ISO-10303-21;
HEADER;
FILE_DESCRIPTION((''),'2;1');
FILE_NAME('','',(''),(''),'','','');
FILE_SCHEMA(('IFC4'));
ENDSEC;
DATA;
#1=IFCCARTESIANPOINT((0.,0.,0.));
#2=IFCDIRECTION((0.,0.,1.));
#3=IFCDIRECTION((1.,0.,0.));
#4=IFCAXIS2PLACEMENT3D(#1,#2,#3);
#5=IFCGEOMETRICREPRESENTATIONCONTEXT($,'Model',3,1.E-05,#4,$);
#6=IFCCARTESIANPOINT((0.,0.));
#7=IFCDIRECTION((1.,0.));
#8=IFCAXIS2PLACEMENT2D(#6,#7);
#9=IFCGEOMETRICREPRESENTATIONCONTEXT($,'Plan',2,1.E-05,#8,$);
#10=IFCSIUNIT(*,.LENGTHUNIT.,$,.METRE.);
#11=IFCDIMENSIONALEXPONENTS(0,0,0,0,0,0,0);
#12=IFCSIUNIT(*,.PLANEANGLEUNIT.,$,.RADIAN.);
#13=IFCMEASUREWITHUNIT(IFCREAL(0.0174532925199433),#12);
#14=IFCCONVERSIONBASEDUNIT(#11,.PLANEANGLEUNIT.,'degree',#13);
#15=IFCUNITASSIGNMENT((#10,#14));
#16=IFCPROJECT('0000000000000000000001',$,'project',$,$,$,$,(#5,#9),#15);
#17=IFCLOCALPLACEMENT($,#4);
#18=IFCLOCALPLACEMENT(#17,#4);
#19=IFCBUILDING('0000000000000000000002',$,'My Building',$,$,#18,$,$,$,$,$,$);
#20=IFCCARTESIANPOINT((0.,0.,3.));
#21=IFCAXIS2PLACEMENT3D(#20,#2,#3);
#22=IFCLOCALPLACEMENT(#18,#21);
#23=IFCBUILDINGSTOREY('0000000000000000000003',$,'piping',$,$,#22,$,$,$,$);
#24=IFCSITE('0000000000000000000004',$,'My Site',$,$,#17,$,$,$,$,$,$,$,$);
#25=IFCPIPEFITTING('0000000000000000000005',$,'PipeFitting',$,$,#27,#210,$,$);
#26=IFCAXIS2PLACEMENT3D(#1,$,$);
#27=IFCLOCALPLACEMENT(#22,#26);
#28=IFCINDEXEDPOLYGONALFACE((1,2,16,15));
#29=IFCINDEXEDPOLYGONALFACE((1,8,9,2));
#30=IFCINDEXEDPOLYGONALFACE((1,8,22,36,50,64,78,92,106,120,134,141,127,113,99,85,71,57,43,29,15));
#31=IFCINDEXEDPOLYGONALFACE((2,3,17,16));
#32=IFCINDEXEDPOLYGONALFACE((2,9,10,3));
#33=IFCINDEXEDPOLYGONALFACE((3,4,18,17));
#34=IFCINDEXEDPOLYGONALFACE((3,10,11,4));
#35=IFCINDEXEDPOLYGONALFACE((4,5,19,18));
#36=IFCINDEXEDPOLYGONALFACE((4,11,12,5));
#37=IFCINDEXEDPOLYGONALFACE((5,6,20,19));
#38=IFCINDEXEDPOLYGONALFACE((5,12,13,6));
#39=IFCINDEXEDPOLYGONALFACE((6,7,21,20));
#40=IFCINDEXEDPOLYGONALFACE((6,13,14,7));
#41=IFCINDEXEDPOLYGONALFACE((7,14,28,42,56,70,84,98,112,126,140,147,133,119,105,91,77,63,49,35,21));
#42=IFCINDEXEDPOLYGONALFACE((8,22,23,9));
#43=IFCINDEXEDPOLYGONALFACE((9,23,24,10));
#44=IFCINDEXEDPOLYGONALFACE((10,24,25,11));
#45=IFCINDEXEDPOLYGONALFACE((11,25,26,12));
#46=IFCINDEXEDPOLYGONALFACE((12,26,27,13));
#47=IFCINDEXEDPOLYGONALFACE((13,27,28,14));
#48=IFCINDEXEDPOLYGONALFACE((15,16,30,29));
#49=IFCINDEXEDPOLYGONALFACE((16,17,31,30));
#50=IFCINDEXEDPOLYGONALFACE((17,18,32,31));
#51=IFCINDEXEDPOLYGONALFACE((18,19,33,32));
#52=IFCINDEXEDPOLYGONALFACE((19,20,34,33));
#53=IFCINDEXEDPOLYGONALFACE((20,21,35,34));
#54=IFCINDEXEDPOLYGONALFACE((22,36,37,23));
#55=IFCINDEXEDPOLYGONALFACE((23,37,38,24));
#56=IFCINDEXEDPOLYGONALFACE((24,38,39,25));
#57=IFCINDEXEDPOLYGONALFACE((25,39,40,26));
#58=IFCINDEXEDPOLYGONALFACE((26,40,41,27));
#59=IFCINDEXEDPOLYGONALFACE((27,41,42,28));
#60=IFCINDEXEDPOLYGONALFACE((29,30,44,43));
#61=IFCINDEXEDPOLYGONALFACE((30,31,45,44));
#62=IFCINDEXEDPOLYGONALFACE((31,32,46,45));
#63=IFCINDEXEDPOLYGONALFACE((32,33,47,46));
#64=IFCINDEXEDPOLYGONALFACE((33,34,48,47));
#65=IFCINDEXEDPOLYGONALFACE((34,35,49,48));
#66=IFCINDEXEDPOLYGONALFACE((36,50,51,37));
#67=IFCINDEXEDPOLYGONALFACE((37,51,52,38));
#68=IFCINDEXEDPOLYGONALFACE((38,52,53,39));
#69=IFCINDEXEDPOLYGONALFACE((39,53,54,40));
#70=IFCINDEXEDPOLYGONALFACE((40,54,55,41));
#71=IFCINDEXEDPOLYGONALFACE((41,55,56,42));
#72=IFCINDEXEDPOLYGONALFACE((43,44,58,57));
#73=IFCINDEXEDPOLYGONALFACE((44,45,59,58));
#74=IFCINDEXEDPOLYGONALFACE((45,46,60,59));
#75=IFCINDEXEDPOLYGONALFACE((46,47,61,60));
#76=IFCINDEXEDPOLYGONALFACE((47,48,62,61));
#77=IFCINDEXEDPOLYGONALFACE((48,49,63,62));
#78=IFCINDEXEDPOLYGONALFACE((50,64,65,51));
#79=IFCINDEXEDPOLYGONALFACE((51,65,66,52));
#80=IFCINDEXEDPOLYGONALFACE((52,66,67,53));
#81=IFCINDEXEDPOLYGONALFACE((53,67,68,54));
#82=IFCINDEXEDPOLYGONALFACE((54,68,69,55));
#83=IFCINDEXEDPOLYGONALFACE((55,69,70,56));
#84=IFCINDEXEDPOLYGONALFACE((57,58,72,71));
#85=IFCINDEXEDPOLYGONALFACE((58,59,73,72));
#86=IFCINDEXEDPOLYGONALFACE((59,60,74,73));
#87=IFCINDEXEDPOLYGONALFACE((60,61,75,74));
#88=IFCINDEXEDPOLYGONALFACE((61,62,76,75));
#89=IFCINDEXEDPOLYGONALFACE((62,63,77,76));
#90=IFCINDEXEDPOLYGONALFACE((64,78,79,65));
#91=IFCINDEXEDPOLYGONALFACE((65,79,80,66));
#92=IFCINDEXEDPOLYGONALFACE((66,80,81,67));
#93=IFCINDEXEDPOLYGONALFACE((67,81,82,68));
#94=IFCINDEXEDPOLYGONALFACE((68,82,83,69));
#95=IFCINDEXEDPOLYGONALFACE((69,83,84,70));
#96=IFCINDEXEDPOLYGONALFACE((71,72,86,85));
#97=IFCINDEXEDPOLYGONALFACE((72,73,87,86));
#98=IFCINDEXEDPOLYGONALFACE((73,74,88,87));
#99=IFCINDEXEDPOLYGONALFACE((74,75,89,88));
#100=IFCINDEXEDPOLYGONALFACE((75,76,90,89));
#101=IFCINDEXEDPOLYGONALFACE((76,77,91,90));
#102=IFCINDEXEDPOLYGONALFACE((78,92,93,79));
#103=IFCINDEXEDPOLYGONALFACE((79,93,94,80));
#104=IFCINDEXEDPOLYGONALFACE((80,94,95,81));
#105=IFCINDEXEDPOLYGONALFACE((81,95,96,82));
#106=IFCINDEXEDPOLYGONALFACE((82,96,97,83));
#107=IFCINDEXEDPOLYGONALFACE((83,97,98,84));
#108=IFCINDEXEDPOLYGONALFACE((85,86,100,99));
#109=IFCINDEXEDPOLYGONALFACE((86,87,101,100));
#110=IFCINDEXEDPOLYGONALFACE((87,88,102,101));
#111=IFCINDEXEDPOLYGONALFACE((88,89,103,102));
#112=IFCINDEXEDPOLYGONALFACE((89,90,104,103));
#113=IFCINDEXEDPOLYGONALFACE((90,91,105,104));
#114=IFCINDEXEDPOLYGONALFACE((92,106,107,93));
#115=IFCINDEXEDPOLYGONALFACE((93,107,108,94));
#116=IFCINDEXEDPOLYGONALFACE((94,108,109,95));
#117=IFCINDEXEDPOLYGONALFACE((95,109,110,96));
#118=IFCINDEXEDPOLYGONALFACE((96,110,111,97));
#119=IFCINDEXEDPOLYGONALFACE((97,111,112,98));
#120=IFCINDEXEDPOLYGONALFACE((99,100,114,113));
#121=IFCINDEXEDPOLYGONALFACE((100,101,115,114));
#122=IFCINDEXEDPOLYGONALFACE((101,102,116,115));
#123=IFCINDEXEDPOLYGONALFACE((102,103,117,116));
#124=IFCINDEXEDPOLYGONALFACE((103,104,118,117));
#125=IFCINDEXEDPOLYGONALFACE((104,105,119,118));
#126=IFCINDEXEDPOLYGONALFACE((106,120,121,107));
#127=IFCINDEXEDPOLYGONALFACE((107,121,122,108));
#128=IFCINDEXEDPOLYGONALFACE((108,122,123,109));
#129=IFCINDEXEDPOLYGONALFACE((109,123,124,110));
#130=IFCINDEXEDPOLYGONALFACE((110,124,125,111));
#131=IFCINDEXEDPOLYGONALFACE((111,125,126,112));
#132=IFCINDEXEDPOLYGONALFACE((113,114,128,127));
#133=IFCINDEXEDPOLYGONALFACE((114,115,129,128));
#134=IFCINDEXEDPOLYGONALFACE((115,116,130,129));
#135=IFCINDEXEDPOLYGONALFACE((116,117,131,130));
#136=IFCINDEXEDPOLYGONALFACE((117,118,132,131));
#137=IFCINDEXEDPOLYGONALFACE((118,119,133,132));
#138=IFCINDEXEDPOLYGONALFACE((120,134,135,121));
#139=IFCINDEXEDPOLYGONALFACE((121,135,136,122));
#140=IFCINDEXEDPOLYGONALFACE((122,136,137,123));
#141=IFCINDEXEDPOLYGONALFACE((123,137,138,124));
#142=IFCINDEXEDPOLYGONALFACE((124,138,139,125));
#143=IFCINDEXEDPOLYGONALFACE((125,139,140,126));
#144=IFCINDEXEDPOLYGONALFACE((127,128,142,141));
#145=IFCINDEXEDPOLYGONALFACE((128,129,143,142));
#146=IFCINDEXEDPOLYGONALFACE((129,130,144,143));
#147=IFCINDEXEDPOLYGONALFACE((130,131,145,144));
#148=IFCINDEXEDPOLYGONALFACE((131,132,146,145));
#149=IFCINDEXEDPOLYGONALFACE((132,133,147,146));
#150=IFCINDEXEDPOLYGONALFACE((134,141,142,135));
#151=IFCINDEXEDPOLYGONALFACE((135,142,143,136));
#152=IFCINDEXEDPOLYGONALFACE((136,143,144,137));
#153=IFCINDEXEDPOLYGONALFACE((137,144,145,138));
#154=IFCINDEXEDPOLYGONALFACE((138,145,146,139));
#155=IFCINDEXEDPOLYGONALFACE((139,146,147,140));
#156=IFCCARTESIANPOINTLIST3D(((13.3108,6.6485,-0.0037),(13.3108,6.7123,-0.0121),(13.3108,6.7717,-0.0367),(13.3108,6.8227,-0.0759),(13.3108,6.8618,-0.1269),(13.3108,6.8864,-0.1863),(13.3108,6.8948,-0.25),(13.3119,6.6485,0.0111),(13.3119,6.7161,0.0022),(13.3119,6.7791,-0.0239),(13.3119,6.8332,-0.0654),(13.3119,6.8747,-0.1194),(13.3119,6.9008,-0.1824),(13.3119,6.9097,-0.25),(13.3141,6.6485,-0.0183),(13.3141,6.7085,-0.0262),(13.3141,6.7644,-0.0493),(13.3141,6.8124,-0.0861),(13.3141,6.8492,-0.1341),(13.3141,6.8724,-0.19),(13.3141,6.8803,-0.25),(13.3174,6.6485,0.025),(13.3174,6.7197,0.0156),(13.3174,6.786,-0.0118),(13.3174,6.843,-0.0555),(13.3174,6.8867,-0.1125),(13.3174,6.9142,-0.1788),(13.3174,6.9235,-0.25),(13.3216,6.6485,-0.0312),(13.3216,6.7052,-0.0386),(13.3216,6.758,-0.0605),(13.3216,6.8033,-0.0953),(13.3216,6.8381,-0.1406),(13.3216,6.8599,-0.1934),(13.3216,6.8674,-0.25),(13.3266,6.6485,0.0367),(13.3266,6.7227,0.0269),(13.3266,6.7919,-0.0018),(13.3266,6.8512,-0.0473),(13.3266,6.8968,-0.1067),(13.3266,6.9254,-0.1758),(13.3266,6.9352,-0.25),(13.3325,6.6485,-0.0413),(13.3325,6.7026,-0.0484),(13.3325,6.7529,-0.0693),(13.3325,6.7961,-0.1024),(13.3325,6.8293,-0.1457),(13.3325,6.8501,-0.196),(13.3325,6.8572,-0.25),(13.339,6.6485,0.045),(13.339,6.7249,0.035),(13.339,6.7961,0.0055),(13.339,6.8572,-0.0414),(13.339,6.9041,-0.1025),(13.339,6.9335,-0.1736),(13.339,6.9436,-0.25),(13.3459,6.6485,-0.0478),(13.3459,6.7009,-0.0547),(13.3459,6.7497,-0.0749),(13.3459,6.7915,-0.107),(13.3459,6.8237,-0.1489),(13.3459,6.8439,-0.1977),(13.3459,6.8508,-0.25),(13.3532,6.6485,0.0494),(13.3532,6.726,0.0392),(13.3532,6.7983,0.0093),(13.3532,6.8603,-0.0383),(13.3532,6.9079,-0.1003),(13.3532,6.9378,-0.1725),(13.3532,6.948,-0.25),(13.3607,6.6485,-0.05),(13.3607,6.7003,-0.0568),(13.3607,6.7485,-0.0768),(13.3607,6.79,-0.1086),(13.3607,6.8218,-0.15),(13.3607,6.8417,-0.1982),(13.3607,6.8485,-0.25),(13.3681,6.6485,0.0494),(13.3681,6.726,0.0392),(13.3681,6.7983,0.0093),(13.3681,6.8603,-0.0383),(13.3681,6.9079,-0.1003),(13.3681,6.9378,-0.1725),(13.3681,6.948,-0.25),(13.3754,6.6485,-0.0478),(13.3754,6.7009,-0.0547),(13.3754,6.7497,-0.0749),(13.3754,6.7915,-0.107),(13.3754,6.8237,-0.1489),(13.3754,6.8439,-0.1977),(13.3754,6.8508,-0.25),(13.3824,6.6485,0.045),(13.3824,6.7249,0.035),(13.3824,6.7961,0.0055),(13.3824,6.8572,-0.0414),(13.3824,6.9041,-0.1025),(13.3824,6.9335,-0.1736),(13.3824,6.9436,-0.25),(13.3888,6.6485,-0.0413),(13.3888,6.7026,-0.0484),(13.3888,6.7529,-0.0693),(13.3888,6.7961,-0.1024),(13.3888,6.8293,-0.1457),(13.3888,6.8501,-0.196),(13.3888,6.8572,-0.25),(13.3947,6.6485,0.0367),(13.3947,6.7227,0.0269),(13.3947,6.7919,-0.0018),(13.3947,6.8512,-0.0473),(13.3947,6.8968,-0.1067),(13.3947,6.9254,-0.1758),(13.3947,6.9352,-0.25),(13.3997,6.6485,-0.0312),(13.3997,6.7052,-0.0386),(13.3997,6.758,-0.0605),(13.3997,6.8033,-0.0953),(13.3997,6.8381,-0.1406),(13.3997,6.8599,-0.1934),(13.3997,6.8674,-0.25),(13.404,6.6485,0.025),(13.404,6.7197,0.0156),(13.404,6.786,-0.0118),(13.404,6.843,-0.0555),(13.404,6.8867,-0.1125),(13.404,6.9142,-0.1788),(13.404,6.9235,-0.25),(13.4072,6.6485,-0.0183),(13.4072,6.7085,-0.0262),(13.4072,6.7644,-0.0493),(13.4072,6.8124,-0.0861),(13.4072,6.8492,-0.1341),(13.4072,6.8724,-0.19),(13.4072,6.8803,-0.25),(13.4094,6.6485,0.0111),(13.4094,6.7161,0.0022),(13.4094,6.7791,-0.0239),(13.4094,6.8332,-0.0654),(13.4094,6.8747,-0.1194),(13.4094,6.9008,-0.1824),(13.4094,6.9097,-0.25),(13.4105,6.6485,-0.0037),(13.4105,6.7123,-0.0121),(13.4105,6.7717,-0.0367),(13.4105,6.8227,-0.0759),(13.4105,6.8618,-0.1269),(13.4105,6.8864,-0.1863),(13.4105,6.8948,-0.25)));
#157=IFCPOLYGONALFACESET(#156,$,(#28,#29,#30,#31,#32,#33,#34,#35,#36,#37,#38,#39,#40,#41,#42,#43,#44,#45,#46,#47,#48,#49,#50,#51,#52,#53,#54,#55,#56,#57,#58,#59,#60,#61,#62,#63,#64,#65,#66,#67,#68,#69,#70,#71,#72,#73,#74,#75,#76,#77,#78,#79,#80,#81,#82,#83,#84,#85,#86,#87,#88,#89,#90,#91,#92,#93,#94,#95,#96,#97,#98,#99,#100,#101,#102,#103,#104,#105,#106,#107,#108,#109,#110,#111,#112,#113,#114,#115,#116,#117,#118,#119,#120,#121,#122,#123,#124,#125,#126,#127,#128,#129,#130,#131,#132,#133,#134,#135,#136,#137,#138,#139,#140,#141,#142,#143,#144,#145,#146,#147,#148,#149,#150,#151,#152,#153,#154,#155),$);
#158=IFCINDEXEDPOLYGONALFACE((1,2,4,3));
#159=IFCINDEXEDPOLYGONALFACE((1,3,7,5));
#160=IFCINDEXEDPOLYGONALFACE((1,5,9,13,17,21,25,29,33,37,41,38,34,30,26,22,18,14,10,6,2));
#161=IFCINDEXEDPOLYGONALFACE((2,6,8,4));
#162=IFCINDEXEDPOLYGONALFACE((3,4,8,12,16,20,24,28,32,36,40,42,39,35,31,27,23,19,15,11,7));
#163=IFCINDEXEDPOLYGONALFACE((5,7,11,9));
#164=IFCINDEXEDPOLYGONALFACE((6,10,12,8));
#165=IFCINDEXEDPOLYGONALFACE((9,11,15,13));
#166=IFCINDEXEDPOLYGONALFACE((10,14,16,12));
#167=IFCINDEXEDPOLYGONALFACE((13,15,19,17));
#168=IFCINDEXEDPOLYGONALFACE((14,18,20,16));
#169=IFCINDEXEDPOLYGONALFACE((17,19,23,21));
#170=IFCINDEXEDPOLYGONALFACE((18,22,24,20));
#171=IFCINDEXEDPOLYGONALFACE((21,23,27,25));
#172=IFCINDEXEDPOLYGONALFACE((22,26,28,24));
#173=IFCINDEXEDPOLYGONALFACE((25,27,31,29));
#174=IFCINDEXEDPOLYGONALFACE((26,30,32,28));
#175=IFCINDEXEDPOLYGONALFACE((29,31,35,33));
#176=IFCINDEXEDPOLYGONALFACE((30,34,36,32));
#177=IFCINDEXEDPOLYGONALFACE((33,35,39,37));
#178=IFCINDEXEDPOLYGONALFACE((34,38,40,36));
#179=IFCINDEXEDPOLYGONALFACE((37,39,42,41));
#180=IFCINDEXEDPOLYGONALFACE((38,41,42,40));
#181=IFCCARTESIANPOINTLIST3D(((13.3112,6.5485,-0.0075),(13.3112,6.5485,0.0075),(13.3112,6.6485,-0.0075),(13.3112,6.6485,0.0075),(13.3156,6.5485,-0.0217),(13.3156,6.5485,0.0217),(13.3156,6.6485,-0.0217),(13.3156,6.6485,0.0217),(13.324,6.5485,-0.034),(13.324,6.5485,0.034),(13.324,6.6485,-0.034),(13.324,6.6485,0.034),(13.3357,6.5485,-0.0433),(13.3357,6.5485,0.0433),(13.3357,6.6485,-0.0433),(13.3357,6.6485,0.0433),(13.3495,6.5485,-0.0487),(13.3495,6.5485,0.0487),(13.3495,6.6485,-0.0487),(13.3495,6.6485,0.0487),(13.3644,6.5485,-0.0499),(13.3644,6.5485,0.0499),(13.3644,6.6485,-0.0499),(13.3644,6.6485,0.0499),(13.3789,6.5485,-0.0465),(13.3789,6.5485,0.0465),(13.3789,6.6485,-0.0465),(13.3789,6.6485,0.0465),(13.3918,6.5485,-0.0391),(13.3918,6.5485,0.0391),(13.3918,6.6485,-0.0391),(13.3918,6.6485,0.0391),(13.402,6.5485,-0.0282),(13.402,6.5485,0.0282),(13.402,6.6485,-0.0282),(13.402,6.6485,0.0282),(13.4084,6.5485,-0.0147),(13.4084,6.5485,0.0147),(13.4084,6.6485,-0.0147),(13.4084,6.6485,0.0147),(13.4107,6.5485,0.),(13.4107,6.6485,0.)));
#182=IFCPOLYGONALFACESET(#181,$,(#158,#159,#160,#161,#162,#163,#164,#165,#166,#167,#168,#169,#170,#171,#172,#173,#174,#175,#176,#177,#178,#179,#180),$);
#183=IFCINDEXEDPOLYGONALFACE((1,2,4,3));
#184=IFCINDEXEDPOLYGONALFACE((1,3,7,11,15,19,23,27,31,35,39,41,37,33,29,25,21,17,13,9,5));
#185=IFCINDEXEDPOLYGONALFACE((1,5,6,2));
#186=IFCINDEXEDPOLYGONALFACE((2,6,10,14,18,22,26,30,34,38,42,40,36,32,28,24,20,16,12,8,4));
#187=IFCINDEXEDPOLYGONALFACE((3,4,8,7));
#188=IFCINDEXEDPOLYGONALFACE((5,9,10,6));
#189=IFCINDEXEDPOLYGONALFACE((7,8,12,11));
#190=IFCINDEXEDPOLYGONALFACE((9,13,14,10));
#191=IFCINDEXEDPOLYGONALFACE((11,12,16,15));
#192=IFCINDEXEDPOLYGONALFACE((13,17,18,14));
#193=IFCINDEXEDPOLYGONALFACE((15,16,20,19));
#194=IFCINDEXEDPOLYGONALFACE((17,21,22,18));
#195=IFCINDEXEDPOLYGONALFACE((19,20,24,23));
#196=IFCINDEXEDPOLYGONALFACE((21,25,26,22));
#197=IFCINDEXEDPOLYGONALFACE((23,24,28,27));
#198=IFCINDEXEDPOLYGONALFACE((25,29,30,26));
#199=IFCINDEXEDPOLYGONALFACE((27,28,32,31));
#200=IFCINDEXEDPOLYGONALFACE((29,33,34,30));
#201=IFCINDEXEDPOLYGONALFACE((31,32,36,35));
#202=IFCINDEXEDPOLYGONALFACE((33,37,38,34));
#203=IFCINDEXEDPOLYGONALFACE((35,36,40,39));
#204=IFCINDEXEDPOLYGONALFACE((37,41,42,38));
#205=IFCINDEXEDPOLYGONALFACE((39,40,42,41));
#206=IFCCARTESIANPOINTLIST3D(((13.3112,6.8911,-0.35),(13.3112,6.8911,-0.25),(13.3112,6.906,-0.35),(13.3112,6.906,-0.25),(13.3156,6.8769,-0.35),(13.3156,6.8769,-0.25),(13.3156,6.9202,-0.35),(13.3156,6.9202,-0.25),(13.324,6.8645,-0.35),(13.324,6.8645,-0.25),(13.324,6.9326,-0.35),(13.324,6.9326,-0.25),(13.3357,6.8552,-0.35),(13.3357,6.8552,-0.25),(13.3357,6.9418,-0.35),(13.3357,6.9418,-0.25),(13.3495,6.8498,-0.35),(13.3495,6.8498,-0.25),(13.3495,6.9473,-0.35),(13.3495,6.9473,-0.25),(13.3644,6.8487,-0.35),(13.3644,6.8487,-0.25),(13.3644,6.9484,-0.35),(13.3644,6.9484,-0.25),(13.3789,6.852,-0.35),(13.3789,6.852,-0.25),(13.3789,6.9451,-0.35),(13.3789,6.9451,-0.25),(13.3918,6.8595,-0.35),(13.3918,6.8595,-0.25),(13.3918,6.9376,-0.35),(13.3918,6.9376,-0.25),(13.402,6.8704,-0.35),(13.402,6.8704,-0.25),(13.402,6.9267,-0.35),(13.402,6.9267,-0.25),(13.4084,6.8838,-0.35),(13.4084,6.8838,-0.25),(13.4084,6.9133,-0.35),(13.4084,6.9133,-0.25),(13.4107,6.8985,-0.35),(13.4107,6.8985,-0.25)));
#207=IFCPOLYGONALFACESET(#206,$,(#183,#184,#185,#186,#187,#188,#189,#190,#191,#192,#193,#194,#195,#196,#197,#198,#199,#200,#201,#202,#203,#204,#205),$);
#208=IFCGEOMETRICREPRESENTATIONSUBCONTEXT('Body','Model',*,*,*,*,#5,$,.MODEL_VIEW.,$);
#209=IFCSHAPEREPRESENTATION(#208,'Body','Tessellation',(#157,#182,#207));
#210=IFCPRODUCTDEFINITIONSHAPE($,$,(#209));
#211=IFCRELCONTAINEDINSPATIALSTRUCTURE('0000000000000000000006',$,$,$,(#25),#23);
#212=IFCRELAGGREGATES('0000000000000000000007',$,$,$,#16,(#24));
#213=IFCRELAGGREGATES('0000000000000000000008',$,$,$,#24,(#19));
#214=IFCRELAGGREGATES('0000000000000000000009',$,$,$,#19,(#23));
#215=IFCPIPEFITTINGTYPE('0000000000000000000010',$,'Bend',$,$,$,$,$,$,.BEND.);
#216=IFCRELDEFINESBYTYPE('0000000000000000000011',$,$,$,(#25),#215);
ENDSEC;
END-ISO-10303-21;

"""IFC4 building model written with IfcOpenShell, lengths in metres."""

from ifc_helpers import new_model, entity, si_unit, converted_unit, frame, origin_with_axes, origin_2d_with_axis, place, context, subcontext, project, spatial, circle, extrude, source, transform, mapped, type_object, type_shapes, element, save


model = new_model("IFC4")

# Units and contexts
model_context = context("Model", 3, precision=1e-05, world=origin_with_axes())
plan_context = context("Plan", 2, precision=1e-05, world=origin_2d_with_axis())
body_context = subcontext(model_context, "Body", "Model", "MODEL_VIEW")
ifc_project = project(units=[si_unit("LENGTHUNIT", "METRE"), converted_unit("PLANEANGLEUNIT", "degree", entity("IfcReal", 0.0174532925199433), si_unit("PLANEANGLEUNIT", "RADIAN"), dimensions=[0, 0, 0, 0, 0, 0, 0])], contexts=[model_context, plan_context])

# Site, building, storey
site_placement = place(None, origin_with_axes())
site = spatial("IfcSite", under=ifc_project, at=site_placement, Name="My Site")
building_placement = place(site_placement, origin_with_axes())
building = spatial("IfcBuilding", under=site, at=building_placement, Name="My Building")
storey_placement = place(building_placement, frame((0.0, 0.0, 3.0), z_axis=(0.0, 0.0, 1.0), x_axis=(1.0, 0.0, 0.0)))
storey = spatial("IfcBuildingStorey", under=building, at=storey_placement, Name="piping")

# Pipe fitting
pipe_fitting_type = type_object("IfcPipeFittingType", Name="Bend", PredefinedType="BEND")
shared_shape = source(origin_with_axes(), body_context, "Body", "SolidModel", [
    entity("IfcSweptDiskSolid", entity("IfcIndexedPolyCurve", entity("IfcCartesianPointList3D", [[0.0, 0.0, -0.1], [0.0, -0.0732, -0.2768], [0.0, -0.25, -0.35]]), [entity("IfcArcIndex", [1, 2, 3])]), 0.05),
    extrude(circle(Radius=0.05), origin_with_axes(), (0.0, 0.0, -1.0), 0.1),
    extrude(circle(Radius=0.05), frame((0.0, -0.25, -0.35), z_axis=(0.0, -1.0, 0.0), x_axis=(1.0, 0.0, 0.0)), (0.0, 0.0, 1.0), 0.1),
])
type_shapes(pipe_fitting_type, [shared_shape])
for number, where, z_axis, x_axis, name in (
    (1, (13.3607, 6.5485, 0.0), (0.0, -1.0, 0.0), (1.0, 0.0, 0.0), "PipeFitting"),
):
    element("IfcPipeFitting", number, at=place(storey_placement, frame(where, z_axis=z_axis, x_axis=x_axis)), inside=storey, type_object=pipe_fitting_type, Name=name, context=body_context, shape_type="MappedRepresentation", body=[
        mapped(shared_shape, transform((0.0, 0.0, 0.0), x_axis=(1.0, 0.0, 0.0), y_axis=(0.0, 1.0, 0.0), z_axis=(0.0, 0.0, 1.0), scale=1.0)),
    ])

save(model, "model.ifc")
